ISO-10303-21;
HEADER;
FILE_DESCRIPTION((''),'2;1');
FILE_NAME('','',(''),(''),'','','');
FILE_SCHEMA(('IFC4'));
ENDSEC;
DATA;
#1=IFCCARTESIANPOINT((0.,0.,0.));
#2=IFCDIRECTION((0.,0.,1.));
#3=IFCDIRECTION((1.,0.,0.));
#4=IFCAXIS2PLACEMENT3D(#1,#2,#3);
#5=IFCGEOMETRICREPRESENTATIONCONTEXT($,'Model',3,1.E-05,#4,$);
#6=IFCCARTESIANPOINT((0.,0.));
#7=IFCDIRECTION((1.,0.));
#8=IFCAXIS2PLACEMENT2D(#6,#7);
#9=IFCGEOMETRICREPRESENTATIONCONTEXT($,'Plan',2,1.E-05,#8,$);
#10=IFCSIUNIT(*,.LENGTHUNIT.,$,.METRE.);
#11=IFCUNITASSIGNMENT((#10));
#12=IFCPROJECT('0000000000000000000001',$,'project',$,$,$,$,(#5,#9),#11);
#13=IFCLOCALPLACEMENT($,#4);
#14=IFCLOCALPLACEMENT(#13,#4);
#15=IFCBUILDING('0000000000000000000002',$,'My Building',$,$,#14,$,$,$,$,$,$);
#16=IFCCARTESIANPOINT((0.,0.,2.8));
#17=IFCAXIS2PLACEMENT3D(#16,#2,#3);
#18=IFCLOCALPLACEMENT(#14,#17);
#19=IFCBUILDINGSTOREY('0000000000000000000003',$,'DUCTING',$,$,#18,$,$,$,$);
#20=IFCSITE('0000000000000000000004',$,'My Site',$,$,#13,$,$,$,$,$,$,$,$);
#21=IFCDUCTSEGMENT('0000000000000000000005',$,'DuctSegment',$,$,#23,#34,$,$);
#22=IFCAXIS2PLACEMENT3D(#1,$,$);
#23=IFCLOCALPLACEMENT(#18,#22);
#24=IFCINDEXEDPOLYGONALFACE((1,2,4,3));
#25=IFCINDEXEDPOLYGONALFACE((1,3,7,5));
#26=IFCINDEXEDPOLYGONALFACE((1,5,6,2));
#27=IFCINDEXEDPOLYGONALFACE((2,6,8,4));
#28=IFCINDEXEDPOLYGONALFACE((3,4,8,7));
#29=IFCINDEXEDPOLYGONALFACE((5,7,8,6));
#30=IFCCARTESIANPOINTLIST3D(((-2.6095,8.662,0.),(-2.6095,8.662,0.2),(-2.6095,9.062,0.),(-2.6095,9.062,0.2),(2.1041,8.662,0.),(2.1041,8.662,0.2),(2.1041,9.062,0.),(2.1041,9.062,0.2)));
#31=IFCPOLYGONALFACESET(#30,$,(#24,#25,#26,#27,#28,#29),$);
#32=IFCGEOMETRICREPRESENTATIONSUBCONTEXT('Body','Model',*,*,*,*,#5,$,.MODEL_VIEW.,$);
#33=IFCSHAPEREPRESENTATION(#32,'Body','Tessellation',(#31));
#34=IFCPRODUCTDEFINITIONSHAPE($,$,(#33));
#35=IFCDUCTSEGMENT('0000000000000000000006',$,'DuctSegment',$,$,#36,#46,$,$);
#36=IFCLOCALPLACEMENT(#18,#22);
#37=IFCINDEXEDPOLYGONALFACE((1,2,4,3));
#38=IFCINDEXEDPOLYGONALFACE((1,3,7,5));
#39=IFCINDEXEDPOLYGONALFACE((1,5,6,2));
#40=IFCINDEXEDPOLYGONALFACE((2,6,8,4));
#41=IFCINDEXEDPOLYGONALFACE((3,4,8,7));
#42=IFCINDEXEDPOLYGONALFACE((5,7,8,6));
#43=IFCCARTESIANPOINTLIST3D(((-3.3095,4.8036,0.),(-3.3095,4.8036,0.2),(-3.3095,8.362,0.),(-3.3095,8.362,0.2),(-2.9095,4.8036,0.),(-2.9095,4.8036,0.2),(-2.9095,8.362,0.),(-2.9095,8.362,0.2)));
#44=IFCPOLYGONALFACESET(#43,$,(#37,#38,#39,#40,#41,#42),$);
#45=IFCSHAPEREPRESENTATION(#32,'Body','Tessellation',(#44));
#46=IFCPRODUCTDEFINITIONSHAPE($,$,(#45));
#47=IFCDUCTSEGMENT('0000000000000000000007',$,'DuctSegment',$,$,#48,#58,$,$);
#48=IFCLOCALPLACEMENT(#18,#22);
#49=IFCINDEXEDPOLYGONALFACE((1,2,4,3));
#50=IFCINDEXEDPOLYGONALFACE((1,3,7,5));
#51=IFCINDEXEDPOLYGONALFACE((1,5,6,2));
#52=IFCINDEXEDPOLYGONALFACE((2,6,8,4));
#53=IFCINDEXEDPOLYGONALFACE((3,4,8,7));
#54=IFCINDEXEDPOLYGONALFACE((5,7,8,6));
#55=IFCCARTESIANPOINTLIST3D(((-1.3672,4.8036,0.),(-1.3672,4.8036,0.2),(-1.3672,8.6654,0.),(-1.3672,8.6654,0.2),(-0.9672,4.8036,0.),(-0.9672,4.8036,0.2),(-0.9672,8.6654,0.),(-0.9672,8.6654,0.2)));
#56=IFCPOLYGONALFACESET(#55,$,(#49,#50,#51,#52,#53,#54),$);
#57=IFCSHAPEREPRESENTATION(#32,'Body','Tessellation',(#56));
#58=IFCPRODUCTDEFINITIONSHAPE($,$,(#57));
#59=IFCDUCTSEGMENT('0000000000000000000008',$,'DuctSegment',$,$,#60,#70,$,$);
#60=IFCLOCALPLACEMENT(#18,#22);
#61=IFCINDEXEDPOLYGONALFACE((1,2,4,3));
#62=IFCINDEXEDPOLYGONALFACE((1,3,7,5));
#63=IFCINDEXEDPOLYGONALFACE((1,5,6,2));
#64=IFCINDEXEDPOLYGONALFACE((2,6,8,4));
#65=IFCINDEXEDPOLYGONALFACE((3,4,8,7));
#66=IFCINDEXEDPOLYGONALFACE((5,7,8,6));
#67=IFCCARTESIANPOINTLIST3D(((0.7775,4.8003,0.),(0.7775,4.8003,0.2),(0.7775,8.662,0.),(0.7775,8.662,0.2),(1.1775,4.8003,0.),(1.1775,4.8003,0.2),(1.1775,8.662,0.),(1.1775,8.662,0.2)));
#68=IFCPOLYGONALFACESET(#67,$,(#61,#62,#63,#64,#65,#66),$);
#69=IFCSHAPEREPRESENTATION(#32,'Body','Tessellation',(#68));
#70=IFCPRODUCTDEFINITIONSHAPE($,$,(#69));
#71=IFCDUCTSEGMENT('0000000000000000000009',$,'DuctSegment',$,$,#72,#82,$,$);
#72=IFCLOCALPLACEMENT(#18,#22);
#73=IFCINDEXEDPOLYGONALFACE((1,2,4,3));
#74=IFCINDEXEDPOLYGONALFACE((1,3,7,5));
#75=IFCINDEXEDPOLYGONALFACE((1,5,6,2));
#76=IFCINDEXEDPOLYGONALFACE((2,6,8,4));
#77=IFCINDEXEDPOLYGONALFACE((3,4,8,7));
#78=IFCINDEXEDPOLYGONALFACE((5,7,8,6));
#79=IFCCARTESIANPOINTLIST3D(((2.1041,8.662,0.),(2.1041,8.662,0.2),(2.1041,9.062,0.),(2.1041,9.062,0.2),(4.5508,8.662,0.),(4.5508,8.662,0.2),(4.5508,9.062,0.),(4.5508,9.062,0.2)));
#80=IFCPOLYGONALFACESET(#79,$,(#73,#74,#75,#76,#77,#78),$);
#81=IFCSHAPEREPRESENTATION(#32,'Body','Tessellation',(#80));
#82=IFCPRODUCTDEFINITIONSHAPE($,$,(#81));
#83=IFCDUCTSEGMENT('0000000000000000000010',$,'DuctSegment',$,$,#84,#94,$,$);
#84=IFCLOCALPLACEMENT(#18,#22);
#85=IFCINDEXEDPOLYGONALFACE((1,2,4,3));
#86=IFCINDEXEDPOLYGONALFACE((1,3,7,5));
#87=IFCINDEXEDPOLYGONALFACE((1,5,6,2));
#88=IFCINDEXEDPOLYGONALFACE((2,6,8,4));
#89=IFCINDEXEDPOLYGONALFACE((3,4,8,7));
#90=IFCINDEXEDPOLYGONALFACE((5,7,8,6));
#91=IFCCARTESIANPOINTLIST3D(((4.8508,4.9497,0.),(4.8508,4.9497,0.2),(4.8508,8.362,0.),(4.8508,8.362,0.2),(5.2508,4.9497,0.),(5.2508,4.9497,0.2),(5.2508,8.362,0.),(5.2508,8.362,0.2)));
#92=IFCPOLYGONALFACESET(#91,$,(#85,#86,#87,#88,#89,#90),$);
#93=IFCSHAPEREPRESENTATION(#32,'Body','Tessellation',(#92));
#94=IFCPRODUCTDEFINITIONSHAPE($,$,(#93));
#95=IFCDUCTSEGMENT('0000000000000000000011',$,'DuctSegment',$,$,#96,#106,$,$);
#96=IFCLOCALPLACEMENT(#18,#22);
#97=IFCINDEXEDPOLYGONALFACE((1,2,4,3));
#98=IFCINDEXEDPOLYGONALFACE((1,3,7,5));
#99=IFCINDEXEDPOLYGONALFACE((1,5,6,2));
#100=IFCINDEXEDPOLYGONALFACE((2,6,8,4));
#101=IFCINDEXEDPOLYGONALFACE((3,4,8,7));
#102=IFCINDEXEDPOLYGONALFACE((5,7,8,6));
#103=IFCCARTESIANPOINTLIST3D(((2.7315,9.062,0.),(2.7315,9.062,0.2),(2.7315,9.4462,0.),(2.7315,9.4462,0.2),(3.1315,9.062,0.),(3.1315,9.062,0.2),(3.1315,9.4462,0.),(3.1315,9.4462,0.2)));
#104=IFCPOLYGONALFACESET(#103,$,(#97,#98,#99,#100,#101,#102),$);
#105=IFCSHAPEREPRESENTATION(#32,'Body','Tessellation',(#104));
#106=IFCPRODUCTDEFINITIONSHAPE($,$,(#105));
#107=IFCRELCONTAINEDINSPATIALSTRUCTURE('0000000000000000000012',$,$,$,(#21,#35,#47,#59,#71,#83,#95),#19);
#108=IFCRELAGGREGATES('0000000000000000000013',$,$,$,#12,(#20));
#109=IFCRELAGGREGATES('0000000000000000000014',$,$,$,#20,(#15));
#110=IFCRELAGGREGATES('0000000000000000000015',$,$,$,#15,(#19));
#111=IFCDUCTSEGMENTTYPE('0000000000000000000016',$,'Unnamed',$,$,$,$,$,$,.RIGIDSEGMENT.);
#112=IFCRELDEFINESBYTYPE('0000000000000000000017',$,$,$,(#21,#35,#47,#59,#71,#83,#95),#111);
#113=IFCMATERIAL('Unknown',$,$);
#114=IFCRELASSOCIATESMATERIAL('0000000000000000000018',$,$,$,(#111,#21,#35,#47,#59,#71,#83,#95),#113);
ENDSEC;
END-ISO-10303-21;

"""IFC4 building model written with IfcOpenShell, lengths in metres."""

from ifc_helpers import new_model, si_unit, frame, origin_with_axes, origin_2d_with_axis, place, context, subcontext, project, spatial, rectangle, extrude, material, material_profile, profile_set, profile_usage, type_object, element, save


model = new_model("IFC4")

# Units and contexts
model_context = context("Model", 3, precision=1e-05, world=origin_with_axes())
plan_context = context("Plan", 2, precision=1e-05, world=origin_2d_with_axis())
body_context = subcontext(model_context, "Body", "Model", "MODEL_VIEW")
ifc_project = project(units=[si_unit("LENGTHUNIT", "METRE")], contexts=[model_context, plan_context])

# Site, building, storey
site_placement = place(None, origin_with_axes())
site = spatial("IfcSite", under=ifc_project, at=site_placement, Name="My Site")
building_placement = place(site_placement, origin_with_axes())
building = spatial("IfcBuilding", under=site, at=building_placement, Name="My Building")
storey_placement = place(building_placement, frame((0.0, 0.0, 2.8), z_axis=(0.0, 0.0, 1.0), x_axis=(1.0, 0.0, 0.0)))
storey = spatial("IfcBuildingStorey", under=building, at=storey_placement, Name="DUCTING")

# Duct segments
ifc_material = material(Name="Unknown")
ifc_material_profile = material_profile(ifc_material, rectangle(XDim=0.4, YDim=0.2))
ifc_profile_set = profile_set([ifc_material_profile])
ifc_profile_usage_1 = profile_usage(ifc_profile_set, cardinal=5)
duct_segment_type = type_object("IfcDuctSegmentType", Name="Unnamed", PredefinedType="RIGIDSEGMENT", material=ifc_profile_set)
duct_segment_1_placement = place(storey_placement, frame((-2.6095, 8.862, 0.1), z_axis=(1.0, 0.0, 0.0), x_axis=(0.0, 1.0, 0.0)))
element("IfcDuctSegment", 1, at=duct_segment_1_placement, inside=storey, type_object=duct_segment_type, material=ifc_profile_usage_1, Name="DuctSegment", context=body_context, shape_type="SweptSolid", body=[
    extrude(rectangle(XDim=0.4, YDim=0.2), origin_with_axes(), (0.0, 0.0, 1.0), 4.7136),
])
ifc_profile_usage_2 = profile_usage(ifc_profile_set, cardinal=5)
duct_segment_2_placement = place(storey_placement, frame((-3.1095, 8.362, 0.1), z_axis=(0.0, -1.0, 0.0), x_axis=(1.0, 0.0, 0.0)))
element("IfcDuctSegment", 2, at=duct_segment_2_placement, inside=storey, type_object=duct_segment_type, material=ifc_profile_usage_2, Name="DuctSegment", context=body_context, shape_type="SweptSolid", body=[
    extrude(rectangle(XDim=0.4, YDim=0.2), origin_with_axes(), (0.0, 0.0, 1.0), 3.5585),
])
ifc_profile_usage_3 = profile_usage(ifc_profile_set, cardinal=5)
duct_segment_3_placement = place(storey_placement, frame((-1.1672, 8.6654, 0.1), z_axis=(0.0, -1.0, 0.0), x_axis=(1.0, 0.0, 0.0)))
element("IfcDuctSegment", 3, at=duct_segment_3_placement, inside=storey, type_object=duct_segment_type, material=ifc_profile_usage_3, Name="DuctSegment", context=body_context, shape_type="SweptSolid", body=[
    extrude(rectangle(XDim=0.4, YDim=0.2), origin_with_axes(), (0.0, 0.0, 1.0), 3.8618),
])
ifc_profile_usage_4 = profile_usage(ifc_profile_set, cardinal=5)
duct_segment_4_placement = place(storey_placement, frame((0.9775, 8.662, 0.1), z_axis=(0.0, -1.0, 0.0), x_axis=(1.0, 0.0, 0.0)))
element("IfcDuctSegment", 4, at=duct_segment_4_placement, inside=storey, type_object=duct_segment_type, material=ifc_profile_usage_4, Name="DuctSegment", context=body_context, shape_type="SweptSolid", body=[
    extrude(rectangle(XDim=0.4, YDim=0.2), origin_with_axes(), (0.0, 0.0, 1.0), 3.8618),
])
ifc_profile_usage_5 = profile_usage(ifc_profile_set, cardinal=5)
duct_segment_5_placement = place(storey_placement, frame((2.1041, 8.862, 0.1), z_axis=(1.0, 0.0, 0.0), x_axis=(0.0, 1.0, 0.0)))
element("IfcDuctSegment", 5, at=duct_segment_5_placement, inside=storey, type_object=duct_segment_type, material=ifc_profile_usage_5, Name="DuctSegment", context=body_context, shape_type="SweptSolid", body=[
    extrude(rectangle(XDim=0.4, YDim=0.2), origin_with_axes(), (0.0, 0.0, 1.0), 2.4467),
])
ifc_profile_usage_6 = profile_usage(ifc_profile_set, cardinal=5)
duct_segment_6_placement = place(storey_placement, frame((5.0508, 8.362, 0.1), z_axis=(0.0, -1.0, 0.0), x_axis=(1.0, 0.0, 0.0)))
element("IfcDuctSegment", 6, at=duct_segment_6_placement, inside=storey, type_object=duct_segment_type, material=ifc_profile_usage_6, Name="DuctSegment", context=body_context, shape_type="SweptSolid", body=[
    extrude(rectangle(XDim=0.4, YDim=0.2), origin_with_axes(), (0.0, 0.0, 1.0), 3.4123),
])
ifc_profile_usage_7 = profile_usage(ifc_profile_set, cardinal=5)
duct_segment_7_placement = place(storey_placement, frame((2.9315, 9.062, 0.1), z_axis=(0.0, 1.0, 0.0), x_axis=(-1.0, 0.0, 0.0)))
element("IfcDuctSegment", 7, at=duct_segment_7_placement, inside=storey, type_object=duct_segment_type, material=ifc_profile_usage_7, Name="DuctSegment", context=body_context, shape_type="SweptSolid", body=[
    extrude(rectangle(XDim=0.4, YDim=0.2), origin_with_axes(), (0.0, 0.0, 1.0), 0.3841),
])

save(model, "model.ifc")
